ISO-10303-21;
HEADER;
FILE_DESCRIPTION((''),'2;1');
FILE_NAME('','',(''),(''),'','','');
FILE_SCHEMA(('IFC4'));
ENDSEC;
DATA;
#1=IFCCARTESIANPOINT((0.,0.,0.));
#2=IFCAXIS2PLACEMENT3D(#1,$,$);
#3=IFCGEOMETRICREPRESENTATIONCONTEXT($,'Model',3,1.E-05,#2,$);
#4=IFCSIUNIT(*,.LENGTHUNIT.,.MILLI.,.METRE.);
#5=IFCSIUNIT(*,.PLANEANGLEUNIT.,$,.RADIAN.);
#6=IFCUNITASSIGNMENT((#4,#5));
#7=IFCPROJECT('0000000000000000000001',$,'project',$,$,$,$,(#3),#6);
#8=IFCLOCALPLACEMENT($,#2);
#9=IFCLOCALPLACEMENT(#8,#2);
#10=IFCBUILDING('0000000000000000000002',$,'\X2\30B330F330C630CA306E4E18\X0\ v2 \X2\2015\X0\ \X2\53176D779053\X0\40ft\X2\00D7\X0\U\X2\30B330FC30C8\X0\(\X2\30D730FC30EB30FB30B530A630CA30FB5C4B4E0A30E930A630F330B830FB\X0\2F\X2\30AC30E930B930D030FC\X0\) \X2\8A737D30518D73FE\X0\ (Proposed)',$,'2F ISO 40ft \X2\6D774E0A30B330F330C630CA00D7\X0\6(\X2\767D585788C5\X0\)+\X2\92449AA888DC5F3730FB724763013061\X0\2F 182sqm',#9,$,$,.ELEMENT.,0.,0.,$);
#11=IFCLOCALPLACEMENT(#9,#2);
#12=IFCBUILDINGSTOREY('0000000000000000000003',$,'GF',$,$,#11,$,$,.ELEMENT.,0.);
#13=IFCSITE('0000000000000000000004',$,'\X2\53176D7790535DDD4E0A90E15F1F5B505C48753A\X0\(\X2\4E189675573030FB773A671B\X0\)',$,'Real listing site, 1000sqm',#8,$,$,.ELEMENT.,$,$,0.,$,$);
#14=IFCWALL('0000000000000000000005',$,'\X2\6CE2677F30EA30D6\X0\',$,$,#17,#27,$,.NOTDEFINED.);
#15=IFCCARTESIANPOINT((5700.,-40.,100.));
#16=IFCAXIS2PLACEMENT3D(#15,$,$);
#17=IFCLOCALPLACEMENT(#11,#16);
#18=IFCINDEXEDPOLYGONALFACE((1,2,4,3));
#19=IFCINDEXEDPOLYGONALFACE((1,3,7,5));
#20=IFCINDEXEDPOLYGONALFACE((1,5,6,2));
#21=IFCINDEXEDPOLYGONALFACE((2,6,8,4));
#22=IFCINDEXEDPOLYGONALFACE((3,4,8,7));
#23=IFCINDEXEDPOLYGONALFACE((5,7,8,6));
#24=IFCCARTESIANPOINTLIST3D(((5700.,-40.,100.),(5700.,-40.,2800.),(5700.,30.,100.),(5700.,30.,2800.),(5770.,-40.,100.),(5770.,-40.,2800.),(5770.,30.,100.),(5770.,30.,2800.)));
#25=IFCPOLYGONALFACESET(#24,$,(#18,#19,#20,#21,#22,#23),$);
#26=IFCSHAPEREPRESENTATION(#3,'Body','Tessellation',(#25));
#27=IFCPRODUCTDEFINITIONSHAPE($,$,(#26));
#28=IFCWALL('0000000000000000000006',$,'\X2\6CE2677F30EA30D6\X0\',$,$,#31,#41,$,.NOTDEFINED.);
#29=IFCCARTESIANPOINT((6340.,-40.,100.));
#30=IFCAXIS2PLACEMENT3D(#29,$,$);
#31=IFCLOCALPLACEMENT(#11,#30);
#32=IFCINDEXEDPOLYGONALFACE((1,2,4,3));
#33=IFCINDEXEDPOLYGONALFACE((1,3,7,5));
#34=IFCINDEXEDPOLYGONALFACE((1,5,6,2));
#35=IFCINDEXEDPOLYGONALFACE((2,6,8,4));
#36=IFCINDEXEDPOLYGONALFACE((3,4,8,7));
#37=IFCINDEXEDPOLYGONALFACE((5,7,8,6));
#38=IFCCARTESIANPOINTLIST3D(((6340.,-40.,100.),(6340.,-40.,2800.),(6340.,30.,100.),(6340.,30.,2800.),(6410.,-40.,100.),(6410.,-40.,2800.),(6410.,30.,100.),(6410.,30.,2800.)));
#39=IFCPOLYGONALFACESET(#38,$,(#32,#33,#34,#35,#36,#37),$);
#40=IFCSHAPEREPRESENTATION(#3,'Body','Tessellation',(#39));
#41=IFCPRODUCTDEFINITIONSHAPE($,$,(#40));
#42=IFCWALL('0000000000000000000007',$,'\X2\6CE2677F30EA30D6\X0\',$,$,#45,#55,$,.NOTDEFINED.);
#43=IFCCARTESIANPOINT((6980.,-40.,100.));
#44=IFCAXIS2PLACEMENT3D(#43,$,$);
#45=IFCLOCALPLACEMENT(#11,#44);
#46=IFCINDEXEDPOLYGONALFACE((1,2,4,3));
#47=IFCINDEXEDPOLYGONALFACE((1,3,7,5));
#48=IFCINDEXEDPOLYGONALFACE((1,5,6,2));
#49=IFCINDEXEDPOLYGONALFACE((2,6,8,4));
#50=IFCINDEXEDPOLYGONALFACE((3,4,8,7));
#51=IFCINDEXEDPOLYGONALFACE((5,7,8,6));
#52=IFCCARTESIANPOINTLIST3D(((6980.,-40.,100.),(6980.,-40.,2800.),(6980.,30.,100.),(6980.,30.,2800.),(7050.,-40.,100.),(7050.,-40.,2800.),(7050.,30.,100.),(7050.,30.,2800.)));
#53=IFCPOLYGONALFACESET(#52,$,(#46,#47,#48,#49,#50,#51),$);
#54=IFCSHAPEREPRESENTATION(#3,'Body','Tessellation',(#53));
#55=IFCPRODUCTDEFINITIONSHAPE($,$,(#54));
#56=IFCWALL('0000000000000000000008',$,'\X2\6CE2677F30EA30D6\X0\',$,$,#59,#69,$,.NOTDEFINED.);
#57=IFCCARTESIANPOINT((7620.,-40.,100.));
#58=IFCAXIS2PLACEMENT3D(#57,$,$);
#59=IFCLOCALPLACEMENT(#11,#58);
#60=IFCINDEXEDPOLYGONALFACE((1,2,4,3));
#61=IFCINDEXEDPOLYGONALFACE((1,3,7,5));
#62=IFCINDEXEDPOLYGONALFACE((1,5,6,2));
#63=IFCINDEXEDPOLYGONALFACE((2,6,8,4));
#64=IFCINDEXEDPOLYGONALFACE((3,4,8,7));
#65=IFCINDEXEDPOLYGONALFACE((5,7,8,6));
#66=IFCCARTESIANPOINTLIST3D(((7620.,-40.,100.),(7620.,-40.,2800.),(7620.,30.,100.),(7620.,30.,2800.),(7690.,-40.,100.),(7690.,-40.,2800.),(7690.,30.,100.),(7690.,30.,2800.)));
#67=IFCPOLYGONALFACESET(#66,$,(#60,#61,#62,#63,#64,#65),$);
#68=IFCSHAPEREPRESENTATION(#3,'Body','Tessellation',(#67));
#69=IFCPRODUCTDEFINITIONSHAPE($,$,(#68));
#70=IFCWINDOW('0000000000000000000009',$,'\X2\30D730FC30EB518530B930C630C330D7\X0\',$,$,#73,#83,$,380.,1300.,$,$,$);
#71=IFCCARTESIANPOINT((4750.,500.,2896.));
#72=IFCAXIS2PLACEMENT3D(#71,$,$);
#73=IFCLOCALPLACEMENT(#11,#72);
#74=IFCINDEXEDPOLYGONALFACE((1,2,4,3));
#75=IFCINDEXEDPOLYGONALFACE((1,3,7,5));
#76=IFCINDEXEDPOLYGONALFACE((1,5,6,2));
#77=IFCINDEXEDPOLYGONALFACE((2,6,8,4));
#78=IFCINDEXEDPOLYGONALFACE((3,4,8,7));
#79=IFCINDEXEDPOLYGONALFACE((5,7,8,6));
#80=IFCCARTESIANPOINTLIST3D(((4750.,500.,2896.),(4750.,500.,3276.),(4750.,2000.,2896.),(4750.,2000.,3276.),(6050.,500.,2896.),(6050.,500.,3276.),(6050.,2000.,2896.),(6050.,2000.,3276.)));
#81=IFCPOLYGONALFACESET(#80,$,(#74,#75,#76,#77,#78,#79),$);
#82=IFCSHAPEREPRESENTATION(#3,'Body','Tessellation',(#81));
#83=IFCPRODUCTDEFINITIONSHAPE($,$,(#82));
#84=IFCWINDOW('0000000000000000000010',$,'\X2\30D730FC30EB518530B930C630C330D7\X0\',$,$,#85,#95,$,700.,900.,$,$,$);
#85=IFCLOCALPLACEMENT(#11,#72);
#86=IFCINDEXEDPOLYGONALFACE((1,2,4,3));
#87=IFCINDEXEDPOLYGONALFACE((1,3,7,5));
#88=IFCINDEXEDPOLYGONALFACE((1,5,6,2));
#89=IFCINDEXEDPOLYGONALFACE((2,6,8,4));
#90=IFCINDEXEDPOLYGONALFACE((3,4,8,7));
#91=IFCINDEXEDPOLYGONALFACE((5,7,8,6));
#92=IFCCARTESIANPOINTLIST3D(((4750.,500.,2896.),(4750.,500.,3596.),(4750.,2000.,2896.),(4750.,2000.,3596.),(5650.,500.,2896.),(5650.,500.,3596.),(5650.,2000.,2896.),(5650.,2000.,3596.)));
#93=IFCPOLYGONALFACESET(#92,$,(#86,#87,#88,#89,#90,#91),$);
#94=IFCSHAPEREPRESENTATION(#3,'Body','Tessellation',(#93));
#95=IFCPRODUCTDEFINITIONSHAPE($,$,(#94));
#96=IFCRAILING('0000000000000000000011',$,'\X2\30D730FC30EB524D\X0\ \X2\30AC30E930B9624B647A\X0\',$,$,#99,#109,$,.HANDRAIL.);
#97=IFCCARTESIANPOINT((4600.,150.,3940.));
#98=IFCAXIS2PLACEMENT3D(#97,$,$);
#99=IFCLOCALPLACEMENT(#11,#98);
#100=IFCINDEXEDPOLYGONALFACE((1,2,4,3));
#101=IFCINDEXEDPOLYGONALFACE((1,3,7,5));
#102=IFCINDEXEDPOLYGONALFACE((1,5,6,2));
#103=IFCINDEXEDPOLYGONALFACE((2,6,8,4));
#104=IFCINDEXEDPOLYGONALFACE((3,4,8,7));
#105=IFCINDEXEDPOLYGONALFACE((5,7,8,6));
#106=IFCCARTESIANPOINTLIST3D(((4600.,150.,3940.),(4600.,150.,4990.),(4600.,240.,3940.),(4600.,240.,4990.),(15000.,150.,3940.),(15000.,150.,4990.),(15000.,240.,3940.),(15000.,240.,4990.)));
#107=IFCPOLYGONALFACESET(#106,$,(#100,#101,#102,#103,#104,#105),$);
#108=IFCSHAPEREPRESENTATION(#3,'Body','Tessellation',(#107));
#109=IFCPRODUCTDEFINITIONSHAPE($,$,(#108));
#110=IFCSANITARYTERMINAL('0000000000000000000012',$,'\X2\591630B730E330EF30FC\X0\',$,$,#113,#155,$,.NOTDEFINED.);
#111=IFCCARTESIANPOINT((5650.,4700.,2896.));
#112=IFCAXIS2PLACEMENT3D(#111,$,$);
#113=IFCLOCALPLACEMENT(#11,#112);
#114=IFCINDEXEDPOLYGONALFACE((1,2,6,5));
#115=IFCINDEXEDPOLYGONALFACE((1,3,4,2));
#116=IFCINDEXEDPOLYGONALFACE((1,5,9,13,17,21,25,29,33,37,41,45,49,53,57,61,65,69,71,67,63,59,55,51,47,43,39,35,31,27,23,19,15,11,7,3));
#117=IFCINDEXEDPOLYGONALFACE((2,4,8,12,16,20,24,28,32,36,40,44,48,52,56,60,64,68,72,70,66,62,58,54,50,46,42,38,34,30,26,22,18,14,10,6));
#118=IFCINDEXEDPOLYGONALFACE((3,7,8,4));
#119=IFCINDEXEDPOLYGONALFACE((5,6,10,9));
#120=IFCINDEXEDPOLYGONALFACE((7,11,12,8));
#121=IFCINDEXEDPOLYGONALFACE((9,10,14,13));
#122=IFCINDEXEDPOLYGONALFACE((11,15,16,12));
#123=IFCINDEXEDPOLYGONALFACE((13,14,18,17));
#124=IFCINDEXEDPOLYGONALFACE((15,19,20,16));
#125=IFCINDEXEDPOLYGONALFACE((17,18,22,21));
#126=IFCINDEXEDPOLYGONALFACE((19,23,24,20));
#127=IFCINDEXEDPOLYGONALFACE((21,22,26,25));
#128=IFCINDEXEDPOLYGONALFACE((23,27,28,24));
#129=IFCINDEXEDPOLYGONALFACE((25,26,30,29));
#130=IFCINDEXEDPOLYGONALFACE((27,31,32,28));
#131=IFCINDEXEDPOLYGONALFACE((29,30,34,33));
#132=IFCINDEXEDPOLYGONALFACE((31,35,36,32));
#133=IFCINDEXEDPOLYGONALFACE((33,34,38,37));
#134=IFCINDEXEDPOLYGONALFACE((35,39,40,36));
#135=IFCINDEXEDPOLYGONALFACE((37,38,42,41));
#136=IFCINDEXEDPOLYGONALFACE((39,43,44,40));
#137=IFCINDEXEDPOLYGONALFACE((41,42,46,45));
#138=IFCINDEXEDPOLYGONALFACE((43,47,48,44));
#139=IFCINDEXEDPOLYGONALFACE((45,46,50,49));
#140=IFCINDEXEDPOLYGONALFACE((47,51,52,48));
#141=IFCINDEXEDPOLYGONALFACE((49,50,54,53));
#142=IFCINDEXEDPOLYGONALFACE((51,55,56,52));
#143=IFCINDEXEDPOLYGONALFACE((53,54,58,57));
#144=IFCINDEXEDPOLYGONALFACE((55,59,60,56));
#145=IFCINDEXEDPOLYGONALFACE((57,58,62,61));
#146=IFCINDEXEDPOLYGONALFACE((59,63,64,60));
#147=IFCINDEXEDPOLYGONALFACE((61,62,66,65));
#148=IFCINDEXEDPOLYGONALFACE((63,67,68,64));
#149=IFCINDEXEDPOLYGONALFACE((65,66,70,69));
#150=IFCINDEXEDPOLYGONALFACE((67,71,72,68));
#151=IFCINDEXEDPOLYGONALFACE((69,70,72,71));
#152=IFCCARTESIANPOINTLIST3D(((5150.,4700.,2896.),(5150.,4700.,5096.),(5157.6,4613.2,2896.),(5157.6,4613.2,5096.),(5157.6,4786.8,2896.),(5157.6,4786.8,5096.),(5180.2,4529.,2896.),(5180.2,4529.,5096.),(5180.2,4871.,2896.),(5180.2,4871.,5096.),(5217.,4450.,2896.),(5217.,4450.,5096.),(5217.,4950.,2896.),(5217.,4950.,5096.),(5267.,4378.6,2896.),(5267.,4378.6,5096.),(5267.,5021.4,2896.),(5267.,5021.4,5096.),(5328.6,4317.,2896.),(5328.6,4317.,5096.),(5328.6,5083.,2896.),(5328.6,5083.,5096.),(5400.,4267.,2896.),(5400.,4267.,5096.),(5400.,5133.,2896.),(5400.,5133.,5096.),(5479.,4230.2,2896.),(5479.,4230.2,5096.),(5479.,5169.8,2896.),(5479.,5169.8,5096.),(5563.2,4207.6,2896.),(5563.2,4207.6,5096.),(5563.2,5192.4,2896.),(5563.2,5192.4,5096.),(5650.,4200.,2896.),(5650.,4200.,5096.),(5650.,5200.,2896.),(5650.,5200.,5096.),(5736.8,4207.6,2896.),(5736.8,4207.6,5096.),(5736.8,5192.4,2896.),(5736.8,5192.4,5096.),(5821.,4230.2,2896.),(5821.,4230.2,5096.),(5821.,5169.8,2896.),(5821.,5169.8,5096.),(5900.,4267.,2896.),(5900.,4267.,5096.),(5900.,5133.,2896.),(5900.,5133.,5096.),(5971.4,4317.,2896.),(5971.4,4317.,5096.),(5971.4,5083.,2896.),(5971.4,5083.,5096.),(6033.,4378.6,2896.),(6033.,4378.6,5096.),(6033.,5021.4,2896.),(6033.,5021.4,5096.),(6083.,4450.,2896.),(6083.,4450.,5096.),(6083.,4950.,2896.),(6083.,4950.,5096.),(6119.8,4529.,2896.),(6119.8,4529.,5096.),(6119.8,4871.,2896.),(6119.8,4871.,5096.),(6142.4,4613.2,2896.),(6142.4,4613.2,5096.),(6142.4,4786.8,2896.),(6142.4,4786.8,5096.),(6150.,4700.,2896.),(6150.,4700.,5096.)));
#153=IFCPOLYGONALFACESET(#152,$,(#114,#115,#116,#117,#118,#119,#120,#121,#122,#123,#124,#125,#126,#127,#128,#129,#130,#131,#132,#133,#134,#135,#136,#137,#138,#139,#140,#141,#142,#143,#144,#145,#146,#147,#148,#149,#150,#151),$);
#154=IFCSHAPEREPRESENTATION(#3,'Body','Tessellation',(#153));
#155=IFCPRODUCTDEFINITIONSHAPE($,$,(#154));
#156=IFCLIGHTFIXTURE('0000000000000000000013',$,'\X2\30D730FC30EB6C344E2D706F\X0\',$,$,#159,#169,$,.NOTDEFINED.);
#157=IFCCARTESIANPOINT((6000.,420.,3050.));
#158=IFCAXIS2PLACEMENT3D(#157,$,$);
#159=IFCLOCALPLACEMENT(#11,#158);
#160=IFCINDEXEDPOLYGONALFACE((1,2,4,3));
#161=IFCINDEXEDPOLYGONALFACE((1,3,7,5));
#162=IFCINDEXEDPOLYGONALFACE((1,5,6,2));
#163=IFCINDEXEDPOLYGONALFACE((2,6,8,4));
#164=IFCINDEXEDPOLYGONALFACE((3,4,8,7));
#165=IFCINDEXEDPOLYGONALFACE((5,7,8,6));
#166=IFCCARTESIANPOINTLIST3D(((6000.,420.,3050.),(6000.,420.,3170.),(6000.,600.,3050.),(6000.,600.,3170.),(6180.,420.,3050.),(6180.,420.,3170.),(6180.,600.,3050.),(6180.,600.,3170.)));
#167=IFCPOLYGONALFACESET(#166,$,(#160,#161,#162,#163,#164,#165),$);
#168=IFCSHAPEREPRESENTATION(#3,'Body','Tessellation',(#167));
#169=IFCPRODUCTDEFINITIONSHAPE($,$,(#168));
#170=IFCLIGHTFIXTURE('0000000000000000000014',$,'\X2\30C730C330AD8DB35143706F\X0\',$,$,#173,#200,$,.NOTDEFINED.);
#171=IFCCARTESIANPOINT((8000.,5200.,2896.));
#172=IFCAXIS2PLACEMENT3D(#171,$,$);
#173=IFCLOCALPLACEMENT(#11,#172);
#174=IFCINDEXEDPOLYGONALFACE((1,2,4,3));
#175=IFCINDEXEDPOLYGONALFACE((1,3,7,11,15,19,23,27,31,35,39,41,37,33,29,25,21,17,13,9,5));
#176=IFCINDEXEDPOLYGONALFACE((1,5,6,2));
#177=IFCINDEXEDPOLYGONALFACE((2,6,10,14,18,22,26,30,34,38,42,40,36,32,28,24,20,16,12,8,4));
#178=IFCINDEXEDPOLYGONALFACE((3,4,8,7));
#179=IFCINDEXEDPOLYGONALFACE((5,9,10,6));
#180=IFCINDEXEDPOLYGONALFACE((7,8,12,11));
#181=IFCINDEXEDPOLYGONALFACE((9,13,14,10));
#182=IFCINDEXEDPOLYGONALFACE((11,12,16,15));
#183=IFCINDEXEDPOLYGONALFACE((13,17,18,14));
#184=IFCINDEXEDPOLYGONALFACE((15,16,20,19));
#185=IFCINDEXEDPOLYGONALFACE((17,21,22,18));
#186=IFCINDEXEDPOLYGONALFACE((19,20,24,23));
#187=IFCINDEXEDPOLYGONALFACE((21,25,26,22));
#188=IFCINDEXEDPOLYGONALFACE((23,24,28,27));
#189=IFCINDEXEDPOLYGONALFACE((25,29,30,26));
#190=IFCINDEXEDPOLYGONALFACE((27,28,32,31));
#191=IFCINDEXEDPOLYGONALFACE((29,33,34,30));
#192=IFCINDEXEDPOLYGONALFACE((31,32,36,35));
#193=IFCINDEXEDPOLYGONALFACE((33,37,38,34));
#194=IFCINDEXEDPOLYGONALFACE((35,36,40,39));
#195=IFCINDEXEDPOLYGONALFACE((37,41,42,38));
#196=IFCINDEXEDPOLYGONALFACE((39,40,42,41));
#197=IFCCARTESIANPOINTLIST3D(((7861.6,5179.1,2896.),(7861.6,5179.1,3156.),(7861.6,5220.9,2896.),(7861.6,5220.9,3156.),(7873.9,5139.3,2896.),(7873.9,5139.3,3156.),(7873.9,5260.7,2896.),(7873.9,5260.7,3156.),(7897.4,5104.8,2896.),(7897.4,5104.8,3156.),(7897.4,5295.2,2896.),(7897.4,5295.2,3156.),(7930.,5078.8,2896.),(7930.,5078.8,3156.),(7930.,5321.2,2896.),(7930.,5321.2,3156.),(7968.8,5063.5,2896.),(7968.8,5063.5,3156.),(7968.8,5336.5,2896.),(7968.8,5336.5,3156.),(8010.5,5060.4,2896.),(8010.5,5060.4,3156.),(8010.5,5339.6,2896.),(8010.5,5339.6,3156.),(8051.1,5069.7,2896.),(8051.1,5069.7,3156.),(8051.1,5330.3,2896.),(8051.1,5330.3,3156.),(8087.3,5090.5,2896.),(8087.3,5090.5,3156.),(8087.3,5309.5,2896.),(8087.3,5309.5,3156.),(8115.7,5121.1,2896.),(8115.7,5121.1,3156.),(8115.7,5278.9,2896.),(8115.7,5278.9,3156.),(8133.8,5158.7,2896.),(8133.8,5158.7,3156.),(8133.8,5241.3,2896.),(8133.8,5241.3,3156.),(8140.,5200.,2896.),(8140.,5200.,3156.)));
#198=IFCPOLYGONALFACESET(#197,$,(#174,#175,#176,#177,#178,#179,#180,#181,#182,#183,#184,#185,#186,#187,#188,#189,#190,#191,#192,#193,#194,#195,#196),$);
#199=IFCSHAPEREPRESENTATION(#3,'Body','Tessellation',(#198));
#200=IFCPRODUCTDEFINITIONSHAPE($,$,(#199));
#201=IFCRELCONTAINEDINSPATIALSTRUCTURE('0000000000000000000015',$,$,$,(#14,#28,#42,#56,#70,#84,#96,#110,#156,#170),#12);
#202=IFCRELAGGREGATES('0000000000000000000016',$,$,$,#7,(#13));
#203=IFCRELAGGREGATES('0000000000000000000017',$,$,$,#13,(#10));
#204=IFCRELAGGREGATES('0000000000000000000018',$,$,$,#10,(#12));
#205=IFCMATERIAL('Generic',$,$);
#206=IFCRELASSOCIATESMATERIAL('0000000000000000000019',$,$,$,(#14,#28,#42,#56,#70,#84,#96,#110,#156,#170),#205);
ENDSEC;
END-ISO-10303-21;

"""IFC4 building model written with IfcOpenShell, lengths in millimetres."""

from ifc_helpers import new_model, si_unit, frame, frame_2d, origin, origin_2d, place, context, project, spatial, rectangle, circle, extrude, material, element, save


model = new_model("IFC4")

# Units and contexts
model_context = context("Model", 3, precision=1e-05, world=origin())
ifc_project = project(units=[si_unit("LENGTHUNIT", "METRE", prefix="MILLI"), si_unit("PLANEANGLEUNIT", "RADIAN")], contexts=[model_context])

# Site, building, storey
site_placement = place(None, origin())
site = spatial("IfcSite", under=ifc_project, at=site_placement, Name="北海道川上郡弟子屈町(丘陵地・眺望)", ObjectType="Real listing site, 1000sqm", CompositionType="ELEMENT", RefElevation=0.0)
building_placement = place(site_placement, origin())
building = spatial("IfcBuilding", under=site, at=building_placement, Name="コンテナの丘 v2 ― 北海道40ft×Uコート(プール・サウナ・屋上ラウンジ・2Fガラスバー) 詳細再現 (Proposed)", ObjectType="2F ISO 40ft 海上コンテナ×6(白塗装)+鉄骨補強・片持ち2F 182sqm", CompositionType="ELEMENT", ElevationOfRefHeight=0.0, ElevationOfTerrain=0.0)
storey_placement = place(building_placement, origin())
storey = spatial("IfcBuildingStorey", under=building, at=storey_placement, Name="GF", CompositionType="ELEMENT", Elevation=0.0)

# Shared definitions
ifc_material = material(Name="Generic")

# Walls
wall_1_placement = place(storey_placement, frame((5700.0, -40.0, 100.0)))
element("IfcWall", 1, at=wall_1_placement, inside=storey, material=ifc_material, Name="波板リブ", PredefinedType="NOTDEFINED", context=model_context, shape_type="SweptSolid", body=[
    extrude(rectangle(XDim=70.0, YDim=70.0, at=frame_2d((35.0, 35.0))), frame((5700.0, -40.0, 100.0)), (0.0, 0.0, 1.0), 2700.0),
])
wall_2_placement = place(storey_placement, frame((6340.0, -40.0, 100.0)))
element("IfcWall", 2, at=wall_2_placement, inside=storey, material=ifc_material, Name="波板リブ", PredefinedType="NOTDEFINED", context=model_context, shape_type="SweptSolid", body=[
    extrude(rectangle(XDim=70.0, YDim=70.0, at=frame_2d((35.0, 35.0))), frame((6340.0, -40.0, 100.0)), (0.0, 0.0, 1.0), 2700.0),
])
wall_3_placement = place(storey_placement, frame((6980.0, -40.0, 100.0)))
element("IfcWall", 3, at=wall_3_placement, inside=storey, material=ifc_material, Name="波板リブ", PredefinedType="NOTDEFINED", context=model_context, shape_type="SweptSolid", body=[
    extrude(rectangle(XDim=70.0, YDim=70.0, at=frame_2d((35.0, 35.0))), frame((6980.0, -40.0, 100.0)), (0.0, 0.0, 1.0), 2700.0),
])
wall_4_placement = place(storey_placement, frame((7620.0, -40.0, 100.0)))
element("IfcWall", 4, at=wall_4_placement, inside=storey, material=ifc_material, Name="波板リブ", PredefinedType="NOTDEFINED", context=model_context, shape_type="SweptSolid", body=[
    extrude(rectangle(XDim=70.0, YDim=70.0, at=frame_2d((35.0, 35.0))), frame((7620.0, -40.0, 100.0)), (0.0, 0.0, 1.0), 2700.0),
])

# Windows
window_1_placement = place(storey_placement, frame((4750.0, 500.0, 2896.0)))
element("IfcWindow", 5, at=window_1_placement, inside=storey, material=ifc_material, Name="プール内ステップ", OverallHeight=380.0, OverallWidth=1300.0, context=model_context, shape_type="SweptSolid", body=[
    extrude(rectangle(XDim=1300.0, YDim=1500.0, at=frame_2d((650.0, 750.0))), frame((4750.0, 500.0, 2896.0)), (0.0, 0.0, 1.0), 380.0),
])
window_2_placement = place(storey_placement, frame((4750.0, 500.0, 2896.0)))
element("IfcWindow", 6, at=window_2_placement, inside=storey, material=ifc_material, Name="プール内ステップ", OverallHeight=700.0, OverallWidth=900.0, context=model_context, shape_type="SweptSolid", body=[
    extrude(rectangle(XDim=900.0, YDim=1500.0, at=frame_2d((450.0, 750.0))), frame((4750.0, 500.0, 2896.0)), (0.0, 0.0, 1.0), 700.0),
])

# Railing
railing_placement = place(storey_placement, frame((4600.0, 150.0, 3940.0)))
element("IfcRailing", 7, at=railing_placement, inside=storey, material=ifc_material, Name="プール前 ガラス手摺", PredefinedType="HANDRAIL", context=model_context, shape_type="SweptSolid", body=[
    extrude(rectangle(XDim=10400.0, YDim=90.0, at=frame_2d((5200.0, 45.0))), frame((4600.0, 150.0, 3940.0)), (0.0, 0.0, 1.0), 1050.0),
])

# Sanitary terminal
sanitary_terminal_placement = place(storey_placement, frame((5650.0, 4700.0, 2896.0)))
element("IfcSanitaryTerminal", 8, at=sanitary_terminal_placement, inside=storey, material=ifc_material, Name="外シャワー", PredefinedType="NOTDEFINED", context=model_context, shape_type="SweptSolid", body=[
    extrude(circle(Radius=500.0, at=origin_2d()), frame((5650.0, 4700.0, 2896.0)), (0.0, 0.0, 1.0), 2200.0),
])

# Light fixtures
light_fixture_1_placement = place(storey_placement, frame((6000.0, 420.0, 3050.0)))
element("IfcLightFixture", 9, at=light_fixture_1_placement, inside=storey, material=ifc_material, Name="プール水中灯", PredefinedType="NOTDEFINED", context=model_context, shape_type="SweptSolid", body=[
    extrude(rectangle(XDim=180.0, YDim=180.0, at=frame_2d((90.0, 90.0))), frame((6000.0, 420.0, 3050.0)), (0.0, 0.0, 1.0), 120.0),
])
light_fixture_2_placement = place(storey_placement, frame((8000.0, 5200.0, 2896.0)))
element("IfcLightFixture", 10, at=light_fixture_2_placement, inside=storey, material=ifc_material, Name="デッキ足元灯", PredefinedType="NOTDEFINED", context=model_context, shape_type="SweptSolid", body=[
    extrude(circle(Radius=140.0, at=origin_2d()), frame((8000.0, 5200.0, 2896.0)), (0.0, 0.0, 1.0), 260.0),
])

save(model, "model.ifc")
